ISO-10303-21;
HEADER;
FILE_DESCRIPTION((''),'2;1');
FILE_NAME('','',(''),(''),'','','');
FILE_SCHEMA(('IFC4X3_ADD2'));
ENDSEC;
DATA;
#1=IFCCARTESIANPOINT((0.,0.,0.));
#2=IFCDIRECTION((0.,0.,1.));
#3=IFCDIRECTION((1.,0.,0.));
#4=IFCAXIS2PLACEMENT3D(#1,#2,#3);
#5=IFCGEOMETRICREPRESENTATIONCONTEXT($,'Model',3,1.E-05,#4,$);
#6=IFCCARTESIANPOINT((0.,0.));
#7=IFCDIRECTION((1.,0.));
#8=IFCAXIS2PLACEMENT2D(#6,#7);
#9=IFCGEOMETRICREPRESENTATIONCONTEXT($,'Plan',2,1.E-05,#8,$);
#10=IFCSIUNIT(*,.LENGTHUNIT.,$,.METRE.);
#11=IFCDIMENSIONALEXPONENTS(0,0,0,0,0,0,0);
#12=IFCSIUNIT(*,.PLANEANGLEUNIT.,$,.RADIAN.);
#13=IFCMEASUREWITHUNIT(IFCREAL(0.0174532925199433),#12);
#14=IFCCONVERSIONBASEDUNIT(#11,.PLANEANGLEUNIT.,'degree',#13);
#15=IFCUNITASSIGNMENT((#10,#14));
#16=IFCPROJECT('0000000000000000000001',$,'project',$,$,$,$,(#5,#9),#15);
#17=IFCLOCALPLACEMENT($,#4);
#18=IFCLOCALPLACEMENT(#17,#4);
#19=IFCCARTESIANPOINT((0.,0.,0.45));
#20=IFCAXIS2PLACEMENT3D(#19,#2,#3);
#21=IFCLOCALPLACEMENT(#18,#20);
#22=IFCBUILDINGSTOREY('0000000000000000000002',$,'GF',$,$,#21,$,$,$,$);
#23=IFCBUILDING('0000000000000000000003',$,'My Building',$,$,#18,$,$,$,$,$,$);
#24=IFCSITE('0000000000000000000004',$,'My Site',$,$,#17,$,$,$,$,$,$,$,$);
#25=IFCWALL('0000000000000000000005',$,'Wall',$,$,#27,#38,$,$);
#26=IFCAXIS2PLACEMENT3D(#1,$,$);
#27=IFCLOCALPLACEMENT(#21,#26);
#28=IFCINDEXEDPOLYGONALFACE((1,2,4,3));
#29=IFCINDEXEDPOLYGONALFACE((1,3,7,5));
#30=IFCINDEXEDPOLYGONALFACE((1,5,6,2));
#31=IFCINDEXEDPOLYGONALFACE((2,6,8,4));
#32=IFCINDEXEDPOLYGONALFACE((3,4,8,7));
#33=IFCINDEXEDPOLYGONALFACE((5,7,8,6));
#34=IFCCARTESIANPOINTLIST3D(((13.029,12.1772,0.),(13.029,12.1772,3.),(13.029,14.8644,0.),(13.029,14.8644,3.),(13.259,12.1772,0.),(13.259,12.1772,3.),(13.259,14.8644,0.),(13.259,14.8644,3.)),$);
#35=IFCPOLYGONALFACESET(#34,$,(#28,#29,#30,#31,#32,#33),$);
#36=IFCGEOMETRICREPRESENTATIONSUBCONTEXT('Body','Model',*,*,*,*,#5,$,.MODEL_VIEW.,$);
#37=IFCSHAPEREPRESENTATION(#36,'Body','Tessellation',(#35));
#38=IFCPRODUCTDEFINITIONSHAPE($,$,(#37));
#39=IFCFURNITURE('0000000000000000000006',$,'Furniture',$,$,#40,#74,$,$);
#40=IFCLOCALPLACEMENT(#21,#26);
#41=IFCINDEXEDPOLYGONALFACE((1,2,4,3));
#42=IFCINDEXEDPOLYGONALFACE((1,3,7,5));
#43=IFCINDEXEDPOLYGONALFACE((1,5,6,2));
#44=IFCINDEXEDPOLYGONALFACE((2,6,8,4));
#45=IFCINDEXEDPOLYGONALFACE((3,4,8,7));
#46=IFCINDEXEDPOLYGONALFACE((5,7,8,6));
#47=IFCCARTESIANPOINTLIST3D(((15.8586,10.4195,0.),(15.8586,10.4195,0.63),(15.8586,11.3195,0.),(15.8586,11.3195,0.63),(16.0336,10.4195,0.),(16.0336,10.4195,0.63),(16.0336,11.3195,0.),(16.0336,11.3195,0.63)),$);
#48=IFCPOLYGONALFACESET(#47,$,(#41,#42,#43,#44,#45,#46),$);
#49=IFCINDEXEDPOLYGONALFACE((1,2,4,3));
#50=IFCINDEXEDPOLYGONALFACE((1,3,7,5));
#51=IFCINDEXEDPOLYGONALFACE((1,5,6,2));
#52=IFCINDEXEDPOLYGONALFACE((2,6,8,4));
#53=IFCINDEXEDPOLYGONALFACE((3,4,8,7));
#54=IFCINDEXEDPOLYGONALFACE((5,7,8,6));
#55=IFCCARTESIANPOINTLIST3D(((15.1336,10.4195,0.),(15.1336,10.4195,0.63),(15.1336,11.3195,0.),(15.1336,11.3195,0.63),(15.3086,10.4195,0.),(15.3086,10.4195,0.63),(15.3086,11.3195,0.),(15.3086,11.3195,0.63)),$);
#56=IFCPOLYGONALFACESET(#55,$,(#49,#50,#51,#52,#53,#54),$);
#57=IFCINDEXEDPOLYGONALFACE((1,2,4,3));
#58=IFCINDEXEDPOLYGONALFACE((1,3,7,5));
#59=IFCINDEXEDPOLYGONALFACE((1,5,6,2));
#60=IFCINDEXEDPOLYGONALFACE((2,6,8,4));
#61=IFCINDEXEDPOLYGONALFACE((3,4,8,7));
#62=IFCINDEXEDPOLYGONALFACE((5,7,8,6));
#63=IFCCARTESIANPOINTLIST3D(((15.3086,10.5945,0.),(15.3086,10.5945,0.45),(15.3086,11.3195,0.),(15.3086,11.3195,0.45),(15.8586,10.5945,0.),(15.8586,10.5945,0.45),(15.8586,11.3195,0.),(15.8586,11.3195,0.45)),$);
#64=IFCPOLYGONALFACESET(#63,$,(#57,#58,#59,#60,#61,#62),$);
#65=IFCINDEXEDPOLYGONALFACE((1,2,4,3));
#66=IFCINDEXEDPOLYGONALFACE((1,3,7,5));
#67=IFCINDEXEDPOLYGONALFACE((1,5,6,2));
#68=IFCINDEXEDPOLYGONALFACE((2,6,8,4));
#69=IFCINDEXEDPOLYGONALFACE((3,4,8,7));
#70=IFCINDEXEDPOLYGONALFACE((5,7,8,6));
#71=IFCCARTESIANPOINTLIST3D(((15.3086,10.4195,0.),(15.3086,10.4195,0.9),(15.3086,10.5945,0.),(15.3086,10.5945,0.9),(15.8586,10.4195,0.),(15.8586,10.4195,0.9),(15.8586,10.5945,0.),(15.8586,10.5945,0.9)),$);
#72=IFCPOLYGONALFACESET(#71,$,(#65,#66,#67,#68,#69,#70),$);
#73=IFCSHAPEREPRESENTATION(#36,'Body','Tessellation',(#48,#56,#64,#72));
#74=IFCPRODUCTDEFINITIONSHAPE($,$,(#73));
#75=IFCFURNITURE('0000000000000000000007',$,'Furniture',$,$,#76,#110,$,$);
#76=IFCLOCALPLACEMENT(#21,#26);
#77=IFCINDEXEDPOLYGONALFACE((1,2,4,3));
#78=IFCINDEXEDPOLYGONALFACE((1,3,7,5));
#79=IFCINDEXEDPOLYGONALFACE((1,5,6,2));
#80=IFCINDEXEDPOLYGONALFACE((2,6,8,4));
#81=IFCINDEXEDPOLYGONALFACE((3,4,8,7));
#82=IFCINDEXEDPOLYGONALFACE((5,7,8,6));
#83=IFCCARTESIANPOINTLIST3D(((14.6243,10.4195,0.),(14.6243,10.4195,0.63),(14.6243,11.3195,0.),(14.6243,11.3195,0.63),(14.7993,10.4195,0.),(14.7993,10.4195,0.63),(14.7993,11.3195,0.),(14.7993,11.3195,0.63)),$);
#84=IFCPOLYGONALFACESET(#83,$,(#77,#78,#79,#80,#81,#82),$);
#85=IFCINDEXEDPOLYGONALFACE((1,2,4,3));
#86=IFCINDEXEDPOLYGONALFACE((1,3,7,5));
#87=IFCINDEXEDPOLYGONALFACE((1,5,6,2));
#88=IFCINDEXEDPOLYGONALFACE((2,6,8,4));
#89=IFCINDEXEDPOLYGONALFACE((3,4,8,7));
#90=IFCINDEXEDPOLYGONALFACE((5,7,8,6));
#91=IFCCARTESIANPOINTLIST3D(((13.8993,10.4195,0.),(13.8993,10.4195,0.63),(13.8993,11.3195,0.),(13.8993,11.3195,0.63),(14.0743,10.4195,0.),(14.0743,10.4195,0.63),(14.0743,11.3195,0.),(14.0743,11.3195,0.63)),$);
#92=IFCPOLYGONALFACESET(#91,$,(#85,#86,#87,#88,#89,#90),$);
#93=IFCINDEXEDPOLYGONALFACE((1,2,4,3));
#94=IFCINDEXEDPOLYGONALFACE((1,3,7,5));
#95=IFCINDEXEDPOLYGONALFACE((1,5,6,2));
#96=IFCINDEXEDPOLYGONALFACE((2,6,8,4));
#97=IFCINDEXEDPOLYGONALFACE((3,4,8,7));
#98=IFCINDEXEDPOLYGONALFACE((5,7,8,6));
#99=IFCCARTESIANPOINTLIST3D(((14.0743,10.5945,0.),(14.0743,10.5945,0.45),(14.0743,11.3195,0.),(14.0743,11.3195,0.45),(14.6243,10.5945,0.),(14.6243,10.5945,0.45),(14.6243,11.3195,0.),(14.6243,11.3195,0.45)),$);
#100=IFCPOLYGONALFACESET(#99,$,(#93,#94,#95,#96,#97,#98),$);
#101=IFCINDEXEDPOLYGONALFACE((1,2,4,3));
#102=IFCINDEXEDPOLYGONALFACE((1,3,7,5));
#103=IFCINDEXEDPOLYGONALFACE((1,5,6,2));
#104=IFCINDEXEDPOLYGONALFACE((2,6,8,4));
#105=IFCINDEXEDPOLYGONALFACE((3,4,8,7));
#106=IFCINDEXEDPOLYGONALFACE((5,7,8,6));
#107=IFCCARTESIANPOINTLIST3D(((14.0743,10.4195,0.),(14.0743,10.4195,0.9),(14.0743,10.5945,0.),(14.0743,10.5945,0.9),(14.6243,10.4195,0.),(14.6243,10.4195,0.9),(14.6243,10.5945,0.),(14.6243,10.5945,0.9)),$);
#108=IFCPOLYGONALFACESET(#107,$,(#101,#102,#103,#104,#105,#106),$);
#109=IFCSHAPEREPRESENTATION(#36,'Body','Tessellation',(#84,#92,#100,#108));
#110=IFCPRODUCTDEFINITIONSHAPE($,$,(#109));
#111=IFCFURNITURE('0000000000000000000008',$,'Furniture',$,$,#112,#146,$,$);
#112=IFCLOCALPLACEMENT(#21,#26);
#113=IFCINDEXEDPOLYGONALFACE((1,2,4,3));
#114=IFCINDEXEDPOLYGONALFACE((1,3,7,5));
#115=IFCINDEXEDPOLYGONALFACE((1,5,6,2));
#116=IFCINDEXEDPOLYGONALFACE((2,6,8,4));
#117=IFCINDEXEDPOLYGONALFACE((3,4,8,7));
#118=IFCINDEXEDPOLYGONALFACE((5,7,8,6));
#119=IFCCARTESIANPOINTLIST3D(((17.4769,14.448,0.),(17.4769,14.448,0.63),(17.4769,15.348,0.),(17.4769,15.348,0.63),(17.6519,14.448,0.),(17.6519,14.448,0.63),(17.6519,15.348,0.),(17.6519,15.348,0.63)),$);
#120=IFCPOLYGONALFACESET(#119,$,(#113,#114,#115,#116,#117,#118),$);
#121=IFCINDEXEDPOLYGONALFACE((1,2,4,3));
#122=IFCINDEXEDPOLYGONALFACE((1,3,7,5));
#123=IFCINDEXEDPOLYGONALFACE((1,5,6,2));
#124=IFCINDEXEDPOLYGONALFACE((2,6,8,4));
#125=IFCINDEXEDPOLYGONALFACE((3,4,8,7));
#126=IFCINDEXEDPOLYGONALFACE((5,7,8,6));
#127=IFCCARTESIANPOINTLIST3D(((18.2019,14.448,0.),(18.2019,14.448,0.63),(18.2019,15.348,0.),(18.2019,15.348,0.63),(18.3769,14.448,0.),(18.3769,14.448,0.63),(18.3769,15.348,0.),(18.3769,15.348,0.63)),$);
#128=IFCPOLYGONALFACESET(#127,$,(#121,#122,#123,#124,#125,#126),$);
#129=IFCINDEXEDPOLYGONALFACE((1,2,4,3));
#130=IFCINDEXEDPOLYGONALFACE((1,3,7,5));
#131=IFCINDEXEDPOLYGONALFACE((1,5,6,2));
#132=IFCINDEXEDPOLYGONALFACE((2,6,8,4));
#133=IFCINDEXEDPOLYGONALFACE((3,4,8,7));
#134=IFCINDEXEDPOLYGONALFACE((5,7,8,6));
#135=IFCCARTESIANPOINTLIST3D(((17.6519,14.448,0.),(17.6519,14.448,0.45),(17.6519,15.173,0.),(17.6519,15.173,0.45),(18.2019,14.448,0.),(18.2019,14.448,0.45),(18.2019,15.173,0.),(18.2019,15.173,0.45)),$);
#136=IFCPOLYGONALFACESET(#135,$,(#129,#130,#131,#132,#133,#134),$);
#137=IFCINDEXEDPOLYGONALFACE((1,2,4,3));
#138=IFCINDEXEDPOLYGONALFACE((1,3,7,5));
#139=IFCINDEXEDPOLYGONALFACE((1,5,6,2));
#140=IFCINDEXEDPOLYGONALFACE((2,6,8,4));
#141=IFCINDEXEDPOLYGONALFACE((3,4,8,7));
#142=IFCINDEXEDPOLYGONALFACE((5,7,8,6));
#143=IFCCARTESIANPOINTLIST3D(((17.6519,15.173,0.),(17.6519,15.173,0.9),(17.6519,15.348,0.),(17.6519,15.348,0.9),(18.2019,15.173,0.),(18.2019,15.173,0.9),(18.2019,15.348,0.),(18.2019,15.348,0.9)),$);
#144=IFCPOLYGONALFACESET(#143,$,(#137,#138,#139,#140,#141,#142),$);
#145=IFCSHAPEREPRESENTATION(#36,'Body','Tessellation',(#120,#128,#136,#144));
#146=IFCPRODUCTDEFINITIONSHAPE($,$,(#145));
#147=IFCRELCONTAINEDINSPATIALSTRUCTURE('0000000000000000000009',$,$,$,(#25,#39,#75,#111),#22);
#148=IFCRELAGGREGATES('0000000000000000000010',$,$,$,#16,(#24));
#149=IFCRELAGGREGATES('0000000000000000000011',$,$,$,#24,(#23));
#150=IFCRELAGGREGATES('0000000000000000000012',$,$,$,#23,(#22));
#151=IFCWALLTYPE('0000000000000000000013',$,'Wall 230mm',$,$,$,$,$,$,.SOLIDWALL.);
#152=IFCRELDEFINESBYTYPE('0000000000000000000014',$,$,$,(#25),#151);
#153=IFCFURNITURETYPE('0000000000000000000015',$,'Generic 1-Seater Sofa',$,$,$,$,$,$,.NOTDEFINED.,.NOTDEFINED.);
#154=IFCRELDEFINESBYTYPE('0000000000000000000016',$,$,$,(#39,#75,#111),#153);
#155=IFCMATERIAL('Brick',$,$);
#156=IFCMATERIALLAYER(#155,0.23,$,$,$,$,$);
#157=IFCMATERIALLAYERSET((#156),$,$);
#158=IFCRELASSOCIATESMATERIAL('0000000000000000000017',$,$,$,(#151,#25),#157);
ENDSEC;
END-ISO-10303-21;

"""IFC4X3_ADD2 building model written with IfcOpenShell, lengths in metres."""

from ifc_helpers import new_model, entity, si_unit, converted_unit, frame, origin_with_axes, origin_2d_with_axis, place, context, subcontext, project, spatial, line, indexed_curve, outline, extrude, shape, source, transform, mapped, material, layer, layer_set, layer_usage, type_object, type_shapes, element, save


model = new_model("IFC4X3_ADD2")

# Units and contexts
model_context = context("Model", 3, precision=1e-05, world=origin_with_axes())
plan_context = context("Plan", 2, precision=1e-05, world=origin_2d_with_axis())
body_context_1 = subcontext(model_context, "Body", "Model", "MODEL_VIEW")
body_context_2 = subcontext(plan_context, "Body", "Plan", "PLAN_VIEW")
ifc_project = project(units=[si_unit("LENGTHUNIT", "METRE"), converted_unit("PLANEANGLEUNIT", "degree", entity("IfcReal", 0.0174532925199433), si_unit("PLANEANGLEUNIT", "RADIAN"), dimensions=[0, 0, 0, 0, 0, 0, 0])], contexts=[model_context, plan_context])

# Site, building, storey
site_placement = place(None, origin_with_axes())
site = spatial("IfcSite", under=ifc_project, at=site_placement, Name="My Site")
building_placement = place(site_placement, origin_with_axes())
building = spatial("IfcBuilding", under=site, at=building_placement, Name="My Building")
storey_placement = place(building_placement, frame((0.0, 0.0, 0.45), z_axis=(0.0, 0.0, 1.0), x_axis=(1.0, 0.0, 0.0)))
storey = spatial("IfcBuildingStorey", under=building, at=storey_placement, Name="GF")

# Shared definitions
ifc_material_1 = material(Name="Brick")
ifc_layer_1 = layer(ifc_material_1, 0.23)
ifc_layer_set_1 = layer_set([ifc_layer_1])
wall_type = type_object("IfcWallType", Name="Wall 230mm", PredefinedType="SOLIDWALL", material=ifc_layer_set_1)

# Wall
ifc_layer_usage_1 = layer_usage(ifc_layer_set_1, "AXIS2", "POSITIVE", 0.0)
wall_1_placement = place(storey_placement, frame((13.259, 12.1772, 0.0), z_axis=(0.0, 0.0, 1.0), x_axis=(0.0, 1.0, 0.0)))
element("IfcWall", 1, at=wall_1_placement, inside=storey, type_object=wall_type, material=ifc_layer_usage_1, Name="Wall", context=body_context_1, shape_type="SweptSolid", body=[
    extrude(outline(indexed_curve([(0.0, 0.0), (0.0, 0.23), (2.6872, 0.23), (2.6872, 0.0), (0.0, 0.0)], self_intersect=False)), origin_with_axes(), (0.0, 0.0, 1.0), 3.0),
])

# Furniture
furniture_type = type_object("IfcFurnitureType", Name="Generic 1-Seater Sofa", AssemblyPlace="NOTDEFINED", PredefinedType="NOTDEFINED")
shared_shape_1 = source(origin_with_axes(), body_context_1, "Body", "SweptSolid", [
    extrude(outline(indexed_curve([(0.0, 0.0), (0.175, 0.0), (0.175, 0.9), (0.0, 0.9)], segments=[line(1, 2, 3, 4, 1)])), frame((-0.45, -0.9, 0.0), z_axis=(0.0, 0.0, 1.0), x_axis=(1.0, 0.0, 0.0)), (0.0, 0.0, 1.0), 0.63),
    extrude(outline(indexed_curve([(0.0, 0.0), (0.175, 0.0), (0.175, 0.9), (0.0, 0.9)], segments=[line(1, 2, 3, 4, 1)])), frame((0.275, -0.9, 0.0), z_axis=(0.0, 0.0, 1.0), x_axis=(1.0, 0.0, 0.0)), (0.0, 0.0, 1.0), 0.63),
    extrude(outline(indexed_curve([(0.175, 0.0), (0.725, 0.0), (0.725, 0.725), (0.175, 0.725)], segments=[line(1, 2, 3, 4, 1)])), frame((-0.45, -0.9, 0.0), z_axis=(0.0, 0.0, 1.0), x_axis=(1.0, 0.0, 0.0)), (0.0, 0.0, 1.0), 0.45),
    extrude(outline(indexed_curve([(0.175, 0.725), (0.725, 0.725), (0.725, 0.9), (0.175, 0.9)], segments=[line(1, 2, 3, 4, 1)])), frame((-0.45, -0.9, 0.0), z_axis=(0.0, 0.0, 1.0), x_axis=(1.0, 0.0, 0.0)), (0.0, 0.0, 1.0), 0.9),
])
shared_shape_2 = source(origin_with_axes(), body_context_2, "Body", "Annotation2D", [
    entity("IfcGeometricCurveSet", [entity("IfcIndexedPolyCurve", entity("IfcCartesianPointList2D", [[0.275, -0.175], [0.275, -0.9], [0.45, -0.9], [0.45, 0.0], [0.275, 0.0], [0.275, -0.9], [-0.275, -0.9], [-0.275, 0.0], [-0.275, -0.175], [0.275, -0.175], [0.275, 0.0], [-0.275, 0.0], [-0.45, 0.0], [-0.45, -0.9], [-0.275, -0.9], [-0.275, -0.175]]))]),
])
type_shapes(furniture_type, [shared_shape_1, shared_shape_2])
for number, where, z_axis, x_axis, name in (
    (2, (15.5836, 10.4195, 0.0), (0.0, 0.0, 1.0), (-1.0, 0.0, 0.0), "Furniture"),
    (3, (14.3493, 10.4195, 0.0), (0.0, 0.0, 1.0), (-1.0, 0.0, 0.0), "Furniture"),
    (4, (17.9269, 15.348, 0.0), (0.0, 0.0, 1.0), (1.0, 0.0, 0.0), "Furniture"),
):
    element("IfcFurniture", number, at=place(storey_placement, frame(where, z_axis=z_axis, x_axis=x_axis)), inside=storey, type_object=furniture_type, Name=name, shapes=[
        shape(body_context_1, "Body", "MappedRepresentation", [mapped(shared_shape_1, transform((0.0, 0.0, 0.0), x_axis=(1.0, 0.0, 0.0), y_axis=(0.0, 1.0, 0.0), z_axis=(0.0, 0.0, 1.0), scale=1.0))]),
        shape(body_context_2, "Body", "MappedRepresentation", [mapped(shared_shape_2, transform((0.0, 0.0, 0.0), x_axis=(1.0, 0.0, 0.0), y_axis=(0.0, 1.0, 0.0), z_axis=(0.0, 0.0, 1.0), scale=1.0))]),
    ])

save(model, "model.ifc")
